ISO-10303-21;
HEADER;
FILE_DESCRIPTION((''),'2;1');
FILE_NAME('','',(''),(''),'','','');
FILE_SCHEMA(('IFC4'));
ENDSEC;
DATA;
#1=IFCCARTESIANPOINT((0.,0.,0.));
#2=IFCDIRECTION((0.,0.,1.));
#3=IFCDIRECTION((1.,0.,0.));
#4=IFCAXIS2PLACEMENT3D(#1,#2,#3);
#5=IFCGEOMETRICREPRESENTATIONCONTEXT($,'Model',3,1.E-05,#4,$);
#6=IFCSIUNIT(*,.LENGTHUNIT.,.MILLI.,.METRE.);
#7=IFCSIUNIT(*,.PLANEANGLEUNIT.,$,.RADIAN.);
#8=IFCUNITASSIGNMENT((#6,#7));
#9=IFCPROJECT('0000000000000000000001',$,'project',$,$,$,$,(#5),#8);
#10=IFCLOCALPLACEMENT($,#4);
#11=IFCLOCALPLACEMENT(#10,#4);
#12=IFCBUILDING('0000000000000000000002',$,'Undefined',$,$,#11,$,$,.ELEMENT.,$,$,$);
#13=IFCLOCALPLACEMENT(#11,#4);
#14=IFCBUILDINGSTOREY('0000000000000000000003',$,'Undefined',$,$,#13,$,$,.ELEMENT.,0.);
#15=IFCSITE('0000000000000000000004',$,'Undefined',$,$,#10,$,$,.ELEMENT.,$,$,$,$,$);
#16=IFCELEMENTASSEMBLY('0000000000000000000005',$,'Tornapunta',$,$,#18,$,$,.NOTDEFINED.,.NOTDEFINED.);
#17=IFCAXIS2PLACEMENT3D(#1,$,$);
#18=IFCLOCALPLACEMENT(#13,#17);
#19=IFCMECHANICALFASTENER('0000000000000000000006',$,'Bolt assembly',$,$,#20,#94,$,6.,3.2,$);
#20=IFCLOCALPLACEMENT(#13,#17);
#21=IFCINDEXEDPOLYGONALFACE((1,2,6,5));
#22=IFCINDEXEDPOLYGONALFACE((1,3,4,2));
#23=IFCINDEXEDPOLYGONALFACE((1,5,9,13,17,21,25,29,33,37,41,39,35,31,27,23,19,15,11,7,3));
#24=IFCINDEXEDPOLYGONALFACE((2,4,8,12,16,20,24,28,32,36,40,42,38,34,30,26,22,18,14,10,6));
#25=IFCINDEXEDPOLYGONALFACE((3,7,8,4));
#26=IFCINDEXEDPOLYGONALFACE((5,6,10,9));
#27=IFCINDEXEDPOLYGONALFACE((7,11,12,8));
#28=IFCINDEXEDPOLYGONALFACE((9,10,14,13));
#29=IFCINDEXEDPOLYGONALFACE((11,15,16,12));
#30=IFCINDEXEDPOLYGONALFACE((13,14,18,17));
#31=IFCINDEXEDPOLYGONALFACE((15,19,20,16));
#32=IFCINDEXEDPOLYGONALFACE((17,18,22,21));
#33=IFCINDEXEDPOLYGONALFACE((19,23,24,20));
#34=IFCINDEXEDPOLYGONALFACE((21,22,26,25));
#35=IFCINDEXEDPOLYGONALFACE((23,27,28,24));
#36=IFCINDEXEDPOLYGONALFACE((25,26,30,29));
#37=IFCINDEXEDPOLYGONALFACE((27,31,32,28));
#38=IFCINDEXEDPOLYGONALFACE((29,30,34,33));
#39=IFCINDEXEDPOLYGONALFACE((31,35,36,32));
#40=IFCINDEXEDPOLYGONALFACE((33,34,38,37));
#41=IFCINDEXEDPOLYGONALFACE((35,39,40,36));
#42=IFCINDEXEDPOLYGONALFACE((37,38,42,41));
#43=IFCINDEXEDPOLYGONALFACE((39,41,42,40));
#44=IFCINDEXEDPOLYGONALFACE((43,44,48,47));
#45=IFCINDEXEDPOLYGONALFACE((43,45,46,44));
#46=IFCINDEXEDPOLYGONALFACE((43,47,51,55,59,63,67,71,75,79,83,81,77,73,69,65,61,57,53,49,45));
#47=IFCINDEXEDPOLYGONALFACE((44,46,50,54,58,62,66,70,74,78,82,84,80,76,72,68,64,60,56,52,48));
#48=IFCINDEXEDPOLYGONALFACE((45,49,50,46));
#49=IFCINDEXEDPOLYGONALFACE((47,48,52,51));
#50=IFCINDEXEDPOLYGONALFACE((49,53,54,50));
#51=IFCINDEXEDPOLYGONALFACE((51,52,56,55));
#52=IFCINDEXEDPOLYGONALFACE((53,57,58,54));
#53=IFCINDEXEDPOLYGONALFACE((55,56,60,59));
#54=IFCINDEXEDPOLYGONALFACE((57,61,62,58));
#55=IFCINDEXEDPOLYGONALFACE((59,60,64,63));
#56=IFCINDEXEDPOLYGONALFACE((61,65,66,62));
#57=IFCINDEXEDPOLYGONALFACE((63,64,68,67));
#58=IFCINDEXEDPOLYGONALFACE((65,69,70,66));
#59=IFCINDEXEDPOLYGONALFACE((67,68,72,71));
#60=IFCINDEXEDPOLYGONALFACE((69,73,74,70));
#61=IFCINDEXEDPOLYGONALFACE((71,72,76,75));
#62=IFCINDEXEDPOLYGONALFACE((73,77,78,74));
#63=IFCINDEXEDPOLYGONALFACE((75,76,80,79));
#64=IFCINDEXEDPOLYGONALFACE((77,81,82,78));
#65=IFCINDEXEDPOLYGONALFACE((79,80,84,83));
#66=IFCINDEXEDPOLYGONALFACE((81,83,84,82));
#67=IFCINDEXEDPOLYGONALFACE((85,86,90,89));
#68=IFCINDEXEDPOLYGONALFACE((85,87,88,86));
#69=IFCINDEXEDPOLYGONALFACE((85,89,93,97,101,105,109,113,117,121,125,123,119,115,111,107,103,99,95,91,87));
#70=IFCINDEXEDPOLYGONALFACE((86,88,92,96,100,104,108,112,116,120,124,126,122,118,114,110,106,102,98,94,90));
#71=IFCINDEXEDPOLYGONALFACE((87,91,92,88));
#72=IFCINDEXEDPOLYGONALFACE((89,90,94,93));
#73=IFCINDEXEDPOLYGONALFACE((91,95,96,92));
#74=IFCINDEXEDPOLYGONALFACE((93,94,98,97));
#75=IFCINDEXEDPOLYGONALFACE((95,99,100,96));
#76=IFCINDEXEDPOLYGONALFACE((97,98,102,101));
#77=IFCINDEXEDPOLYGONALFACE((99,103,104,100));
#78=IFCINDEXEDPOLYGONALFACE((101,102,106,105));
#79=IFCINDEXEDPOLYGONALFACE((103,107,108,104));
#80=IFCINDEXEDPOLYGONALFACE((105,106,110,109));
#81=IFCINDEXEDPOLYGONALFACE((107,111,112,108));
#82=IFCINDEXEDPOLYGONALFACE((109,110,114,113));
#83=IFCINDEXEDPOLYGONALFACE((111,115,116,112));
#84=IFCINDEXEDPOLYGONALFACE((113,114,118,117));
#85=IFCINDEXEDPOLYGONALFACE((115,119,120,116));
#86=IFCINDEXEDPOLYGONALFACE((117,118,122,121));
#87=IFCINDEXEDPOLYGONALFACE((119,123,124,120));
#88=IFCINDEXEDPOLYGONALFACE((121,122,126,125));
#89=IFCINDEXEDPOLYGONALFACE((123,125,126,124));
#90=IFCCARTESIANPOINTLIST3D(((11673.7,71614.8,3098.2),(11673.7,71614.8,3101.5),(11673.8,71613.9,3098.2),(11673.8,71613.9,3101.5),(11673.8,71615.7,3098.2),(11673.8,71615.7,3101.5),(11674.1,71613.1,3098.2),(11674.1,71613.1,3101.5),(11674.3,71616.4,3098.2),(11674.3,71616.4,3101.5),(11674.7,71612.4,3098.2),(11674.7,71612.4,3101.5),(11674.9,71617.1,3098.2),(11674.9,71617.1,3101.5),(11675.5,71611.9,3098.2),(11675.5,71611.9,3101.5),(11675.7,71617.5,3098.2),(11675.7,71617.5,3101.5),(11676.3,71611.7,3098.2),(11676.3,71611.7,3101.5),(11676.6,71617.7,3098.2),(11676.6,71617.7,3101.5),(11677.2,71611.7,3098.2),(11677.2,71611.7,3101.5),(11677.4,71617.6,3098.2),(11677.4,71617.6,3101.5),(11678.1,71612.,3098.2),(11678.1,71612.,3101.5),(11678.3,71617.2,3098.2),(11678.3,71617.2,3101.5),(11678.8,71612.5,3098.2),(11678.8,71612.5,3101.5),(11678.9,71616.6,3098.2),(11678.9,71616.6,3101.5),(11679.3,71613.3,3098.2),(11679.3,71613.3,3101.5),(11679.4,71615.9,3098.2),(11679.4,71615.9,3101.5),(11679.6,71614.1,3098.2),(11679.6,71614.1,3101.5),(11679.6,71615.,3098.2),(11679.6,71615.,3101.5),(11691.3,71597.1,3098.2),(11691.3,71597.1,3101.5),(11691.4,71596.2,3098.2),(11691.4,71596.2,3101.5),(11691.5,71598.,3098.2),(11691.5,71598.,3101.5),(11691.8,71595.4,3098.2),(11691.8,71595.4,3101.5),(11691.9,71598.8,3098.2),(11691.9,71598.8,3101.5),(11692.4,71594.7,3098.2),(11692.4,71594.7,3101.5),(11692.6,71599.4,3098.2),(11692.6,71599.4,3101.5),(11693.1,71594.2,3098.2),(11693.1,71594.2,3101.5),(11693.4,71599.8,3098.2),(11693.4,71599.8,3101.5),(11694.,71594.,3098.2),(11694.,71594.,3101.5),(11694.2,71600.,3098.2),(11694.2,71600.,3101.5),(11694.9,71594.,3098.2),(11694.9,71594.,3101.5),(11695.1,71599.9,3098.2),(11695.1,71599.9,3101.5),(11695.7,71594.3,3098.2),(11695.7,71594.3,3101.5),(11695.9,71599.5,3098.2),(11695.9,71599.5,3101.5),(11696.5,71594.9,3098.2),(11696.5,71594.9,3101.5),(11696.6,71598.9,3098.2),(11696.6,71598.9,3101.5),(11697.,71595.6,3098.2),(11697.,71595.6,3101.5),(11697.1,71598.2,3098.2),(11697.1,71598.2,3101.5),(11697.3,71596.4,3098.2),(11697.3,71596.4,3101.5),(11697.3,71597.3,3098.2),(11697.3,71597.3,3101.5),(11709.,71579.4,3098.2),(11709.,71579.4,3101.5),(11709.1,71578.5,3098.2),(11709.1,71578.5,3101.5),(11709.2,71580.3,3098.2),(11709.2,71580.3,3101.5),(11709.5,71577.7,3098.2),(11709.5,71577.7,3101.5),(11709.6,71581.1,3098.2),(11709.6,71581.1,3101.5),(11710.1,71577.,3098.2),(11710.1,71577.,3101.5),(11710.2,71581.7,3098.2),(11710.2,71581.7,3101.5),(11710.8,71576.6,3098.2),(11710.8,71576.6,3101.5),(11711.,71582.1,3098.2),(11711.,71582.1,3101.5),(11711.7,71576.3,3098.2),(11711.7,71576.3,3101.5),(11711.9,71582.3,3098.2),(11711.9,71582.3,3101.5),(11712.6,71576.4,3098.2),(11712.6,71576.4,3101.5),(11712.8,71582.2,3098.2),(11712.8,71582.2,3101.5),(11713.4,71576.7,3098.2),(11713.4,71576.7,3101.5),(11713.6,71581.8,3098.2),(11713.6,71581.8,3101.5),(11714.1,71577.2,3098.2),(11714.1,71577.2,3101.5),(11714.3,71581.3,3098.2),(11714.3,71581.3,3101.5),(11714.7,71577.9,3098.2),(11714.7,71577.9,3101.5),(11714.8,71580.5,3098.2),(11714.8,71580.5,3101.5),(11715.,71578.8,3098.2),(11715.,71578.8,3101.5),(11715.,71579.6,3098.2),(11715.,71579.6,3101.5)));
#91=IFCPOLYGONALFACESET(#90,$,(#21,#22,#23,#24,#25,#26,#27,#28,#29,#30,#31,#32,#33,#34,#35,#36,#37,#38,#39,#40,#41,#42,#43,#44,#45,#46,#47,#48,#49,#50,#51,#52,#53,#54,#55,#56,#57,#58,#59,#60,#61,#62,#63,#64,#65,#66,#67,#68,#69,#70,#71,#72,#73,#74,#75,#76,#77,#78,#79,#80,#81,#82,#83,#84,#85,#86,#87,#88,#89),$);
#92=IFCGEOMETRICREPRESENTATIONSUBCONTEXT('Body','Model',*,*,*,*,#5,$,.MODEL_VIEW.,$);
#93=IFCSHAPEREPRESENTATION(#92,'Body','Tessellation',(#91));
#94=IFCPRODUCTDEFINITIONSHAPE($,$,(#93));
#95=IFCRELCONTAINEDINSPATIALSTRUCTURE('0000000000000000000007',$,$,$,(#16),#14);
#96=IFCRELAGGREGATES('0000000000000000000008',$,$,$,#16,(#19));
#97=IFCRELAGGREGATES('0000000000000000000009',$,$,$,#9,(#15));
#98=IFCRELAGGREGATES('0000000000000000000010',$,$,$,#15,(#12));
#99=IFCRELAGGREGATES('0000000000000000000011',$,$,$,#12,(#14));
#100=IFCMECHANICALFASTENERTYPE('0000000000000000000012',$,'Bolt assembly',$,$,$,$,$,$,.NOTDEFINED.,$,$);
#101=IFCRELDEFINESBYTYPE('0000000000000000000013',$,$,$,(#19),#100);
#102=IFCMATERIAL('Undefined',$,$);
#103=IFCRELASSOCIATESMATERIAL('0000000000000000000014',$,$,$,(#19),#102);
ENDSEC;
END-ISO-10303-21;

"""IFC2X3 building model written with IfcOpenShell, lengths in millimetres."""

from ifc_helpers import new_model, si_unit, frame, origin_with_axes, origin_2d_with_axis, place, context, subcontext, project, spatial, circle, extrude, source, transform, mapped, material, type_object, element, aggregate, save


model = new_model("IFC2X3")

# Units and contexts
model_context = context("Model", 3, precision=1e-05, world=origin_with_axes())
body_context = subcontext(model_context, "Body", "Model", "MODEL_VIEW")
ifc_project = project(units=[si_unit("LENGTHUNIT", "METRE", prefix="MILLI"), si_unit("PLANEANGLEUNIT", "RADIAN")], contexts=[model_context])

# Site, building, storey
site_placement = place(None, origin_with_axes())
site = spatial("IfcSite", under=ifc_project, at=site_placement, Name="Undefined", CompositionType="ELEMENT")
building_placement = place(site_placement, origin_with_axes())
building = spatial("IfcBuilding", under=site, at=building_placement, Name="Undefined", CompositionType="ELEMENT")
storey_placement = place(building_placement, origin_with_axes())
storey = spatial("IfcBuildingStorey", under=building, at=storey_placement, Name="Undefined", CompositionType="ELEMENT", Elevation=0.0)

# Element assembly
assembly_1_placement = place(storey_placement, origin_with_axes())
assembly_1 = element("IfcElementAssembly", 1, at=assembly_1_placement, inside=storey, Name="Tornapunta", AssemblyPlace="NOTDEFINED", PredefinedType="NOTDEFINED")

# Mechanical fastener
ifc_material_1 = material(Name="Undefined")
mechanical_fastener_type = type_object("IfcMechanicalFastenerType", Name="Bolt assembly")
shared_shape_1 = source(origin_with_axes(), body_context, "Body", "SweptSolid", [
    extrude(circle(Radius=3.0, at=origin_2d_with_axis()), frame((0.0, -3.2, 0.0), z_axis=(0.0, 1.0, 0.0), x_axis=(1.0, 0.0, 0.0)), (0.0, 0.0, 1.0), 3.3),
])
mechanical_fastener_1_placement = place(assembly_1_placement, frame((11676.7, 71614.7, 3098.3), z_axis=(0.707107, 0.707107, -0.000016), x_axis=(0.707107, -0.707107, 0.000016)))
mechanical_fastener_1 = element("IfcMechanicalFastener", 2, at=mechanical_fastener_1_placement, type_object=mechanical_fastener_type, material=ifc_material_1, Name="Bolt assembly", NominalDiameter=6.0, NominalLength=3.2, context=body_context, shape_type="MappedRepresentation", body=[
    mapped(shared_shape_1, transform((0.0, 0.0, 0.0))),
    mapped(shared_shape_1, transform((25.0, 0.0, 0.0))),
    mapped(shared_shape_1, transform((50.0, 0.0, 0.0))),
])
aggregate(assembly_1, [mechanical_fastener_1])

save(model, "model.ifc")
